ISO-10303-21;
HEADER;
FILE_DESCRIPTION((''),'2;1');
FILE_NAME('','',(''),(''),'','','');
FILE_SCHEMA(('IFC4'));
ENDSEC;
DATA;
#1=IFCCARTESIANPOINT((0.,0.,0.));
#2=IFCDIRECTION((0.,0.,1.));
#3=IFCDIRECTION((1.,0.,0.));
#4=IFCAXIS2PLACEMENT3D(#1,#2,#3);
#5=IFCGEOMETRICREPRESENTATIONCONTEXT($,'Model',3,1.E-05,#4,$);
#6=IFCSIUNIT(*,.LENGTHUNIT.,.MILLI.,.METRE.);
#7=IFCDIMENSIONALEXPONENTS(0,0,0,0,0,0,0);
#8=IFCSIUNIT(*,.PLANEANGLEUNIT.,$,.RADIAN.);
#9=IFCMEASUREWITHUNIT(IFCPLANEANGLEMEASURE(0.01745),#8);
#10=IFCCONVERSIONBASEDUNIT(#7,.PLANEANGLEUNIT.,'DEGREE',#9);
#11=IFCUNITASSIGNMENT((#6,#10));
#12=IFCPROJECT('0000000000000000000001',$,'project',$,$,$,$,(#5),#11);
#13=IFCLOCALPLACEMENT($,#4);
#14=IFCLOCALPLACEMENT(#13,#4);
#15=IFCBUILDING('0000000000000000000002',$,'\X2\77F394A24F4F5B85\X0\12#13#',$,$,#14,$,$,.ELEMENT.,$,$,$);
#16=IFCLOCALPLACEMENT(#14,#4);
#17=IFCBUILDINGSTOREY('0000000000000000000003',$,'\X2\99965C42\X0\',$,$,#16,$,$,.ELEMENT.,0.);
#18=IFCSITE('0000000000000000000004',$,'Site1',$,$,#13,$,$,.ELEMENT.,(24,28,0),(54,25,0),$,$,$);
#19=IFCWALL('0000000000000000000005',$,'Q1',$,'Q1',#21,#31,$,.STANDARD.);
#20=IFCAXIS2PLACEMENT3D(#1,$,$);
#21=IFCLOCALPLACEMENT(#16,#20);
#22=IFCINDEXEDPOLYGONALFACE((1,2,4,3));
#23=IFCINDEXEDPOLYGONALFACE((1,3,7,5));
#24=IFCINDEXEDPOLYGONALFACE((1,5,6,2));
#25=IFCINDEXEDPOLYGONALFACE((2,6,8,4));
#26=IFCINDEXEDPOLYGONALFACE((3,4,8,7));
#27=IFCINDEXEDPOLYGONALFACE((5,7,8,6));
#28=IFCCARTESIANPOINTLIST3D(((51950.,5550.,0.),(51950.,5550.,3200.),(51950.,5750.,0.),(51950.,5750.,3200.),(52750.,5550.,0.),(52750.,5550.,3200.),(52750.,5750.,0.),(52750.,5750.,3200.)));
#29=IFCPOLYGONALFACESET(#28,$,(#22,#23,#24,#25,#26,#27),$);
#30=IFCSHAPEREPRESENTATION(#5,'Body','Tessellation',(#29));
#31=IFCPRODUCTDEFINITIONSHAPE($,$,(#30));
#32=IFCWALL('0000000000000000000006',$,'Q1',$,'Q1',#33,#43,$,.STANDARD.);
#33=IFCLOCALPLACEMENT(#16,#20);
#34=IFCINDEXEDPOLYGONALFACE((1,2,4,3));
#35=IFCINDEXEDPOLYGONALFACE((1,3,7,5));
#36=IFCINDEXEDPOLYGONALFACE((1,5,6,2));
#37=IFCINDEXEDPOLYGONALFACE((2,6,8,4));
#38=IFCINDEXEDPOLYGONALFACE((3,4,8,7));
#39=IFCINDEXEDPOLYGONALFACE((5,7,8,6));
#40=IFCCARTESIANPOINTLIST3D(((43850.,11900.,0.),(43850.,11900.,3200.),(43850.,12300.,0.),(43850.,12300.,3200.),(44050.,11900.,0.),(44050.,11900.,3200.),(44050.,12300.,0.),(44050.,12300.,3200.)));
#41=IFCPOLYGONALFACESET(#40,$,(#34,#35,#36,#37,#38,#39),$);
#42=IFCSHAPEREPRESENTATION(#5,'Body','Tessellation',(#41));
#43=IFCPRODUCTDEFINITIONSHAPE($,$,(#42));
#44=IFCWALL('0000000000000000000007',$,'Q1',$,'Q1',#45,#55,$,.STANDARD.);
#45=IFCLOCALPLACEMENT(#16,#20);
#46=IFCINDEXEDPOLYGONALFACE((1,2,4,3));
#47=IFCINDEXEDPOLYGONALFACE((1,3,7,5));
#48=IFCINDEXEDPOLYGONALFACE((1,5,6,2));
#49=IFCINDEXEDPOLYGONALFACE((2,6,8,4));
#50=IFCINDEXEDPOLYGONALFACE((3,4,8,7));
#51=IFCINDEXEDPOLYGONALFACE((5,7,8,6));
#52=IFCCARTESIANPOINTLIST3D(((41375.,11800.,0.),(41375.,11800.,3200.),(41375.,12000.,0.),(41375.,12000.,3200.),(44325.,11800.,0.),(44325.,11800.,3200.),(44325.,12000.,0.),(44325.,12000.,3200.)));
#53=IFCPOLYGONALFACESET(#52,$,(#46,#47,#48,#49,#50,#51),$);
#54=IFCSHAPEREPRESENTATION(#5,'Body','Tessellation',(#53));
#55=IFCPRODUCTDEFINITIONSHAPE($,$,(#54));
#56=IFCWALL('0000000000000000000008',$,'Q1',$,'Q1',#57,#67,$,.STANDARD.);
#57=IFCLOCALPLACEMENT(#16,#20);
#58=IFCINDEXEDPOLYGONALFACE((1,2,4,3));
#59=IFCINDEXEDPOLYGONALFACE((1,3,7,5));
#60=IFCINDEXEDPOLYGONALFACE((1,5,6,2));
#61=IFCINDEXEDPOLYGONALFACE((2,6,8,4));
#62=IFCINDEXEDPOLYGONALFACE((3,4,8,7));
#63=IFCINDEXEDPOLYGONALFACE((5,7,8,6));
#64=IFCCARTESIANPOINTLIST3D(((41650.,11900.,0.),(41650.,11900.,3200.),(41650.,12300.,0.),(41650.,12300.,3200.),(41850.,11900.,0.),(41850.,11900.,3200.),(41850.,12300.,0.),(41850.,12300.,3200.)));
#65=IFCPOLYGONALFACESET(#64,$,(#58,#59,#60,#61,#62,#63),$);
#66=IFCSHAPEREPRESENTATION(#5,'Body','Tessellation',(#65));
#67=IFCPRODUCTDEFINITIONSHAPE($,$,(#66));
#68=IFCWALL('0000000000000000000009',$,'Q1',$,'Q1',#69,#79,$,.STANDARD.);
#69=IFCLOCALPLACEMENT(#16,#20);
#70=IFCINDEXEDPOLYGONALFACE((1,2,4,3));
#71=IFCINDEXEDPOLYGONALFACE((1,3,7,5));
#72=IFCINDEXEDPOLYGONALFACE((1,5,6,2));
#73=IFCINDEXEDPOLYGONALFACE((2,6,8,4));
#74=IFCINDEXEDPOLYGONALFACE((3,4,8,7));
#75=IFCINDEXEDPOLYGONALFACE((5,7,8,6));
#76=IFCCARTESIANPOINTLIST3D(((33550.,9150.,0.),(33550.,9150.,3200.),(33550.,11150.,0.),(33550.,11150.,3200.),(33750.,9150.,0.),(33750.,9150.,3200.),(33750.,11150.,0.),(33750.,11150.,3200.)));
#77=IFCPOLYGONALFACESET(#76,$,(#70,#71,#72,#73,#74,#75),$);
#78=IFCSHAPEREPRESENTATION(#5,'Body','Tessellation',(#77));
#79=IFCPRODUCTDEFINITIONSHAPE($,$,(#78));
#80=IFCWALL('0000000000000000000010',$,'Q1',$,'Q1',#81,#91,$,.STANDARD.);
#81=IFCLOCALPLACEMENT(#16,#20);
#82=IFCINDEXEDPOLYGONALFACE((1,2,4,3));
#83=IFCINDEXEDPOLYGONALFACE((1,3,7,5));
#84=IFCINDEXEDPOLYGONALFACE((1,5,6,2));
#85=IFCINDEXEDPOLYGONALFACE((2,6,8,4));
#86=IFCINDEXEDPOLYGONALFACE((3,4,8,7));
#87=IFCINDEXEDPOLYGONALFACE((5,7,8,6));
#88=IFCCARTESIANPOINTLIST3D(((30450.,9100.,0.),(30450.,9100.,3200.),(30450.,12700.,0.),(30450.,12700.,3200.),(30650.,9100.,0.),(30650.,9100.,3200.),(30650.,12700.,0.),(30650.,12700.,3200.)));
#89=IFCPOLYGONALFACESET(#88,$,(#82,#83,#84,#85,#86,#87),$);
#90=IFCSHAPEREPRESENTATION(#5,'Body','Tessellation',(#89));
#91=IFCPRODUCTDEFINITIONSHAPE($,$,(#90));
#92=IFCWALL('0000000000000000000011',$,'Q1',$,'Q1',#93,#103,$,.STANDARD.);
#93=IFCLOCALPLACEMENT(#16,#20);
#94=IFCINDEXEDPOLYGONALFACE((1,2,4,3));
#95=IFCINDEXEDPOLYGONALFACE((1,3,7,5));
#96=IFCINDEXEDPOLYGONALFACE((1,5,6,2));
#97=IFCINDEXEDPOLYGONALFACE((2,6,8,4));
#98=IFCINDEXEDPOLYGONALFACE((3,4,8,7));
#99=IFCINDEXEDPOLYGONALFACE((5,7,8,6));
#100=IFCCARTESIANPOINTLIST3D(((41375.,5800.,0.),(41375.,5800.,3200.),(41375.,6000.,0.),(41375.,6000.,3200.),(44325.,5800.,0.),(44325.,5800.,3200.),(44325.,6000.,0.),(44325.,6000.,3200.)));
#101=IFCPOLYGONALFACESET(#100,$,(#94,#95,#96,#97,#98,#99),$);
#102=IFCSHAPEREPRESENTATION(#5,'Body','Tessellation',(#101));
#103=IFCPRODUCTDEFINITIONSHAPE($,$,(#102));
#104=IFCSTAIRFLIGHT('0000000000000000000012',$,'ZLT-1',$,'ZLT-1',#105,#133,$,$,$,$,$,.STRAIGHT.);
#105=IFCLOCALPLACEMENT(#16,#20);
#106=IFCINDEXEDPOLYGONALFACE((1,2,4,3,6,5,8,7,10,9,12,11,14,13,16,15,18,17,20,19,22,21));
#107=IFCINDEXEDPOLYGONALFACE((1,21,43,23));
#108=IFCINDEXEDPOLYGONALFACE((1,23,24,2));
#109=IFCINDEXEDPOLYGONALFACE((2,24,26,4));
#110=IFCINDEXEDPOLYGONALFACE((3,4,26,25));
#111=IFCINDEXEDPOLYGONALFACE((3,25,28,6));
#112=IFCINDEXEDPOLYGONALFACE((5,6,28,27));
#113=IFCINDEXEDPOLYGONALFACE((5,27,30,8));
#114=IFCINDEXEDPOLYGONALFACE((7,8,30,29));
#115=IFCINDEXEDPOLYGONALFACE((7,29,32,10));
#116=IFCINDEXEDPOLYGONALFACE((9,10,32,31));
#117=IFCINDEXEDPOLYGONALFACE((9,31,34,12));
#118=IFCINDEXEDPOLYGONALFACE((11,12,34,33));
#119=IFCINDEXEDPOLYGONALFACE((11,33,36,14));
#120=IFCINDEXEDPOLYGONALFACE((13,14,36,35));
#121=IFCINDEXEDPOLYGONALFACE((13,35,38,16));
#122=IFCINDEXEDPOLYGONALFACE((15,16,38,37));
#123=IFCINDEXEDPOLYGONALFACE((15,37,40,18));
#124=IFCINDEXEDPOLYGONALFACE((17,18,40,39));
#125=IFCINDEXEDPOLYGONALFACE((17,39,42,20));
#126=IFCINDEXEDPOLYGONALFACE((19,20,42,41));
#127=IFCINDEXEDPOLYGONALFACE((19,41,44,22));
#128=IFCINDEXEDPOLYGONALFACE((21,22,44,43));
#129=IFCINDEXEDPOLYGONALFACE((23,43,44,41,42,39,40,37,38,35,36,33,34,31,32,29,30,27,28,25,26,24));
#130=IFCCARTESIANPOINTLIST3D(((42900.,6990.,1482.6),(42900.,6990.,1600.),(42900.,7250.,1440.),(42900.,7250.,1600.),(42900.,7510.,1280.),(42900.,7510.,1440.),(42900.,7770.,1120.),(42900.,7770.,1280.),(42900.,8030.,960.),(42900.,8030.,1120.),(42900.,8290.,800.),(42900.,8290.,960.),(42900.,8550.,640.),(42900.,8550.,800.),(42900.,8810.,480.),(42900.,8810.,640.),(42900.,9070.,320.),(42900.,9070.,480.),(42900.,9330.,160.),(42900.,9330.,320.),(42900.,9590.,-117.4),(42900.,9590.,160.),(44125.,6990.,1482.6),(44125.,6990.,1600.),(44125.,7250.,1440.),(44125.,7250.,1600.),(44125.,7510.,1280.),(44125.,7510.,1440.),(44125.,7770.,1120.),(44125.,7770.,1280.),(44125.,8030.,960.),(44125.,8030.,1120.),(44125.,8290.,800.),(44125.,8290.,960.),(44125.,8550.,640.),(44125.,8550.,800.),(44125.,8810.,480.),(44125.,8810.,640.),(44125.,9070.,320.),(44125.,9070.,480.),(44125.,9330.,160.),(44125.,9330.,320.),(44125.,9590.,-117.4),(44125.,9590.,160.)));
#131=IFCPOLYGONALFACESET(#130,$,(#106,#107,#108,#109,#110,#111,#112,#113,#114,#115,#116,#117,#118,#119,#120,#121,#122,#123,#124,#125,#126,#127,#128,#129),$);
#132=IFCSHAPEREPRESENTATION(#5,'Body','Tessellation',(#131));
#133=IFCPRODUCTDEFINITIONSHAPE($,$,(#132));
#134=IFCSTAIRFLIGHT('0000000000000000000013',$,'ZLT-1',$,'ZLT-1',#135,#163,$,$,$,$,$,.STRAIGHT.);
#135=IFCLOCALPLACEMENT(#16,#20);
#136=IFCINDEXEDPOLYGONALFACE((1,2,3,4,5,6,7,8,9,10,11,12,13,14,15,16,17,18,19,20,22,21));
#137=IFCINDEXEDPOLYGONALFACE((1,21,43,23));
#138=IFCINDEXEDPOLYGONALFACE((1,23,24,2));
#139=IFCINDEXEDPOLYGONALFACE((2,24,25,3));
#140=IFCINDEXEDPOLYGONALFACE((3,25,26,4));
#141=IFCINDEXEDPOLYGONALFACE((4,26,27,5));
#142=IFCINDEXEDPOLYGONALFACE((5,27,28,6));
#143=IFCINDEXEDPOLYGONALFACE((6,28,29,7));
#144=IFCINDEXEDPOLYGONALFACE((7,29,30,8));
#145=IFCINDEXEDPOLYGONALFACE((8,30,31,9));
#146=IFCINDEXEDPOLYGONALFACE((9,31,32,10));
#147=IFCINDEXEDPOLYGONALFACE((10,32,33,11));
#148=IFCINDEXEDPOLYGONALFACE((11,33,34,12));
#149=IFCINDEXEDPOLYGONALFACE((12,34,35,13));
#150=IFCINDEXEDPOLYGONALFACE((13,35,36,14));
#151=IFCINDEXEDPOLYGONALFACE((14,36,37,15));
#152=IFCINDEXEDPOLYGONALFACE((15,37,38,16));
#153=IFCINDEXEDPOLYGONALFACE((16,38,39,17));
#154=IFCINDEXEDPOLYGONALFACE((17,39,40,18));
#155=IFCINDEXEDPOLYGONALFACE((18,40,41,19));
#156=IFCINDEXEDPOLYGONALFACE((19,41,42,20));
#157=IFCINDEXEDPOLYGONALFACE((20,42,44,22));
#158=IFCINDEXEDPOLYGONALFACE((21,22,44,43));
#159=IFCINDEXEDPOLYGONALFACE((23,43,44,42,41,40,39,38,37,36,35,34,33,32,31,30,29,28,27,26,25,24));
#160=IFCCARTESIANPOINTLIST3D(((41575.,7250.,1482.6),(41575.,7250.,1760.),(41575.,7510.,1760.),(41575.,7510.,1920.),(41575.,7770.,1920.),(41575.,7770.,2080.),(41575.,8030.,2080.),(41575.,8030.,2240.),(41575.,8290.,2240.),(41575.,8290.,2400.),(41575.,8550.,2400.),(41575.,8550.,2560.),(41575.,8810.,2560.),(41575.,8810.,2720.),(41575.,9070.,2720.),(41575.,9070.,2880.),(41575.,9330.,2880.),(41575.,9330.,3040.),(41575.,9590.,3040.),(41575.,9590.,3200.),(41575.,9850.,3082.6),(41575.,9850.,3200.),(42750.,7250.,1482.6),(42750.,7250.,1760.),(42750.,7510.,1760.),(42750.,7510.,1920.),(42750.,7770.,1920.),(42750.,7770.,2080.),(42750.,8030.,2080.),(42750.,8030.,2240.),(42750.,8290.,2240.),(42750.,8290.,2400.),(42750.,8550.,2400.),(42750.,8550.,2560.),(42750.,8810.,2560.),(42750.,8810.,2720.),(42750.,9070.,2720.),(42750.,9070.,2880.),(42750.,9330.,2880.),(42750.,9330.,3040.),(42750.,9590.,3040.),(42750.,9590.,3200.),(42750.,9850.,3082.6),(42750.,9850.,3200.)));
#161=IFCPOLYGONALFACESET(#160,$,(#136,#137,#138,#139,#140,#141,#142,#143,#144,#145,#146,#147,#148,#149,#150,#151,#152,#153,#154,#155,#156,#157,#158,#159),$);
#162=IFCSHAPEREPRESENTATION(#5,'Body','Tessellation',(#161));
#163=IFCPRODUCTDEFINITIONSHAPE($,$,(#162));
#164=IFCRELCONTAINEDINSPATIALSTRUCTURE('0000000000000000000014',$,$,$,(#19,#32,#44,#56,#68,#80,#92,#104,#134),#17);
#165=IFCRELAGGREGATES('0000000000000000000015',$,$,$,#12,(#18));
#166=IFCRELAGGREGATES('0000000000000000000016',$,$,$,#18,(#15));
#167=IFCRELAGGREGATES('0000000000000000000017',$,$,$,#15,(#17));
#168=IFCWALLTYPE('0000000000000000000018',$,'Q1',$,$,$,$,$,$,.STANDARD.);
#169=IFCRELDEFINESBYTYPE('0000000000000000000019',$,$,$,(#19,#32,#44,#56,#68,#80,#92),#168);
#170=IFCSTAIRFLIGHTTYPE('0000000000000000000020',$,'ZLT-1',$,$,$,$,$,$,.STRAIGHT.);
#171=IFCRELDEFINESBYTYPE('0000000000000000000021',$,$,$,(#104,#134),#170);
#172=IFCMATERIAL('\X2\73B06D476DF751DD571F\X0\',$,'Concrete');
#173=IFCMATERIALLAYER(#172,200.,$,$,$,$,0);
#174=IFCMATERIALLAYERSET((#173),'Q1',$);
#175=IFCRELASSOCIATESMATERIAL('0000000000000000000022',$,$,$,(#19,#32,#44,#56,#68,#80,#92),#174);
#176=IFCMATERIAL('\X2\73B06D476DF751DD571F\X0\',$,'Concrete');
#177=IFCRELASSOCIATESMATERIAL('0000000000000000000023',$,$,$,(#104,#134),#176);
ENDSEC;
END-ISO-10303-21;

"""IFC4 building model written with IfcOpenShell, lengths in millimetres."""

from ifc_helpers import new_model, entity, si_unit, converted_unit, frame, origin_with_axes, place, context, project, spatial, polyline, outline, extrude, material, layer, layer_set, type_object, element, save


model = new_model("IFC4")

# Units and contexts
model_context = context("Model", 3, precision=1e-05, world=origin_with_axes())
ifc_project = project(units=[si_unit("LENGTHUNIT", "METRE", prefix="MILLI"), converted_unit("PLANEANGLEUNIT", "DEGREE", entity("IfcPlaneAngleMeasure", 0.01745), si_unit("PLANEANGLEUNIT", "RADIAN"), dimensions=[0, 0, 0, 0, 0, 0, 0])], contexts=[model_context])

# Site, building, storey
site_placement = place(None, origin_with_axes())
site = spatial("IfcSite", under=ifc_project, at=site_placement, Name="Site1", CompositionType="ELEMENT", RefLatitude=(24, 28, 0), RefLongitude=(54, 25, 0))
building_placement = place(site_placement, origin_with_axes())
building = spatial("IfcBuilding", under=site, at=building_placement, Name="石钢住宅12#13#", CompositionType="ELEMENT")
storey_placement = place(building_placement, origin_with_axes())
storey = spatial("IfcBuildingStorey", under=building, at=storey_placement, Name="首层", CompositionType="ELEMENT", Elevation=0.0)

# Walls
ifc_material_1 = material(Name="现浇混凝土", Category="Concrete")
ifc_layer = layer(ifc_material_1, 200.0, Priority=0)
ifc_layer_set = layer_set([ifc_layer], Name="Q1")
wall_type = type_object("IfcWallType", Name="Q1", PredefinedType="STANDARD")
wall_1_placement = place(storey_placement, origin_with_axes())
element("IfcWall", 1, at=wall_1_placement, inside=storey, type_object=wall_type, material=ifc_layer_set, Name="Q1", ObjectType="Q1", PredefinedType="STANDARD", context=model_context, shape_type="SweptSolid", body=[
    extrude(outline(polyline([(0.0, 0.0), (3200.0, 0.0), (3200.0, 800.0), (0.0, 800.0), (0.0, 0.0)])), frame((51950.0, 5750.0, 3200.0), z_axis=(0.0, -1.0, 0.0), x_axis=(0.0, 0.0, -1.0)), (0.0, 0.0, 1.0), 200.0),
])
wall_2_placement = place(storey_placement, origin_with_axes())
element("IfcWall", 2, at=wall_2_placement, inside=storey, type_object=wall_type, material=ifc_layer_set, Name="Q1", ObjectType="Q1", PredefinedType="STANDARD", context=model_context, shape_type="SweptSolid", body=[
    extrude(outline(polyline([(0.0, 0.0), (3200.0, 0.0), (3200.0, 400.0), (0.0, 400.0), (0.0, 0.0)])), frame((43850.0, 11900.0, 3200.0), z_axis=(1.0, 0.0, 0.0), x_axis=(0.0, 0.0, -1.0)), (0.0, 0.0, 1.0), 200.0),
])
wall_3_placement = place(storey_placement, origin_with_axes())
element("IfcWall", 3, at=wall_3_placement, inside=storey, type_object=wall_type, material=ifc_layer_set, Name="Q1", ObjectType="Q1", PredefinedType="STANDARD", context=model_context, shape_type="SweptSolid", body=[
    extrude(outline(polyline([(0.0, 0.0), (3200.0, 0.0), (3200.0, 2950.0), (0.0, 2950.0), (0.0, 0.0)])), frame((41375.0, 12000.0, 3200.0), z_axis=(0.0, -1.0, 0.0), x_axis=(0.0, 0.0, -1.0)), (0.0, 0.0, 1.0), 200.0),
])
wall_4_placement = place(storey_placement, origin_with_axes())
element("IfcWall", 4, at=wall_4_placement, inside=storey, type_object=wall_type, material=ifc_layer_set, Name="Q1", ObjectType="Q1", PredefinedType="STANDARD", context=model_context, shape_type="SweptSolid", body=[
    extrude(outline(polyline([(0.0, 0.0), (3200.0, 0.0), (3200.0, 400.0), (0.0, 400.0), (0.0, 0.0)])), frame((41650.0, 11900.0, 3200.0), z_axis=(1.0, 0.0, 0.0), x_axis=(0.0, 0.0, -1.0)), (0.0, 0.0, 1.0), 200.0),
])
wall_5_placement = place(storey_placement, origin_with_axes())
element("IfcWall", 5, at=wall_5_placement, inside=storey, type_object=wall_type, material=ifc_layer_set, Name="Q1", ObjectType="Q1", PredefinedType="STANDARD", context=model_context, shape_type="SweptSolid", body=[
    extrude(outline(polyline([(0.0, 0.0), (3200.0, 0.0), (3200.0, 2000.0), (0.0, 2000.0), (0.0, 0.0)])), frame((33550.0, 9150.0, 3200.0), z_axis=(1.0, 0.0, 0.0), x_axis=(0.0, 0.0, -1.0)), (0.0, 0.0, 1.0), 200.0),
])
wall_6_placement = place(storey_placement, origin_with_axes())
element("IfcWall", 6, at=wall_6_placement, inside=storey, type_object=wall_type, material=ifc_layer_set, Name="Q1", ObjectType="Q1", PredefinedType="STANDARD", context=model_context, shape_type="SweptSolid", body=[
    extrude(outline(polyline([(0.0, 0.0), (3200.0, 0.0), (3200.0, 3600.0), (0.0, 3600.0), (0.0, 0.0)])), frame((30450.0, 9100.0, 3200.0), z_axis=(1.0, 0.0, 0.0), x_axis=(0.0, 0.0, -1.0)), (0.0, 0.0, 1.0), 200.0),
])
wall_7_placement = place(storey_placement, origin_with_axes())
element("IfcWall", 7, at=wall_7_placement, inside=storey, type_object=wall_type, material=ifc_layer_set, Name="Q1", ObjectType="Q1", PredefinedType="STANDARD", context=model_context, shape_type="SweptSolid", body=[
    extrude(outline(polyline([(0.0, 0.0), (3200.0, 0.0), (3200.0, 2950.0), (0.0, 2950.0), (0.0, 0.0)])), frame((41375.0, 6000.0, 3200.0), z_axis=(0.0, -1.0, 0.0), x_axis=(0.0, 0.0, -1.0)), (0.0, 0.0, 1.0), 200.0),
])

# Stair flights
ifc_material_2 = material(Name="现浇混凝土", Category="Concrete")
stair_flight_type = type_object("IfcStairFlightType", Name="ZLT-1", PredefinedType="STRAIGHT")
stair_flight_1_placement = place(storey_placement, origin_with_axes())
element("IfcStairFlight", 8, at=stair_flight_1_placement, inside=storey, type_object=stair_flight_type, material=ifc_material_2, Name="ZLT-1", ObjectType="ZLT-1", PredefinedType="STRAIGHT", context=model_context, shape_type="SweptSolid", body=[
    extrude(outline(polyline([(0.0, -117.4), (2600.0, 1482.6), (2600.0, 1600.0), (2340.0, 1600.0), (2340.0, 1440.0), (2080.0, 1440.0), (2080.0, 1280.0), (1820.0, 1280.0), (1820.0, 1120.0), (1560.0, 1120.0), (1560.0, 960.0), (1300.0, 960.0), (1300.0, 800.0), (1040.0, 800.0), (1040.0, 640.0), (780.0, 640.0), (780.0, 480.0), (520.0, 480.0), (520.0, 320.0), (260.0, 320.0), (260.0, 160.0), (0.0, 160.0), (0.0, -117.4)])), frame((44125.0, 9590.0, 0.0), z_axis=(-1.0, 0.0, 0.0), x_axis=(0.0, -1.0, 0.0)), (0.0, 0.0, 1.0), 1225.0),
])
stair_flight_2_placement = place(storey_placement, origin_with_axes())
element("IfcStairFlight", 9, at=stair_flight_2_placement, inside=storey, type_object=stair_flight_type, material=ifc_material_2, Name="ZLT-1", ObjectType="ZLT-1", PredefinedType="STRAIGHT", context=model_context, shape_type="SweptSolid", body=[
    extrude(outline(polyline([(0.0, -117.4), (2600.0, 1482.6), (2600.0, 1600.0), (2340.0, 1600.0), (2340.0, 1440.0), (2080.0, 1440.0), (2080.0, 1280.0), (1820.0, 1280.0), (1820.0, 1120.0), (1560.0, 1120.0), (1560.0, 960.0), (1300.0, 960.0), (1300.0, 800.0), (1040.0, 800.0), (1040.0, 640.0), (780.0, 640.0), (780.0, 480.0), (520.0, 480.0), (520.0, 320.0), (260.0, 320.0), (260.0, 160.0), (0.0, 160.0), (0.0, -117.4)])), frame((41575.0, 7250.0, 1600.0), z_axis=(1.0, 0.0, 0.0), x_axis=(0.0, 1.0, 0.0)), (0.0, 0.0, 1.0), 1175.0),
])

save(model, "model.ifc")
